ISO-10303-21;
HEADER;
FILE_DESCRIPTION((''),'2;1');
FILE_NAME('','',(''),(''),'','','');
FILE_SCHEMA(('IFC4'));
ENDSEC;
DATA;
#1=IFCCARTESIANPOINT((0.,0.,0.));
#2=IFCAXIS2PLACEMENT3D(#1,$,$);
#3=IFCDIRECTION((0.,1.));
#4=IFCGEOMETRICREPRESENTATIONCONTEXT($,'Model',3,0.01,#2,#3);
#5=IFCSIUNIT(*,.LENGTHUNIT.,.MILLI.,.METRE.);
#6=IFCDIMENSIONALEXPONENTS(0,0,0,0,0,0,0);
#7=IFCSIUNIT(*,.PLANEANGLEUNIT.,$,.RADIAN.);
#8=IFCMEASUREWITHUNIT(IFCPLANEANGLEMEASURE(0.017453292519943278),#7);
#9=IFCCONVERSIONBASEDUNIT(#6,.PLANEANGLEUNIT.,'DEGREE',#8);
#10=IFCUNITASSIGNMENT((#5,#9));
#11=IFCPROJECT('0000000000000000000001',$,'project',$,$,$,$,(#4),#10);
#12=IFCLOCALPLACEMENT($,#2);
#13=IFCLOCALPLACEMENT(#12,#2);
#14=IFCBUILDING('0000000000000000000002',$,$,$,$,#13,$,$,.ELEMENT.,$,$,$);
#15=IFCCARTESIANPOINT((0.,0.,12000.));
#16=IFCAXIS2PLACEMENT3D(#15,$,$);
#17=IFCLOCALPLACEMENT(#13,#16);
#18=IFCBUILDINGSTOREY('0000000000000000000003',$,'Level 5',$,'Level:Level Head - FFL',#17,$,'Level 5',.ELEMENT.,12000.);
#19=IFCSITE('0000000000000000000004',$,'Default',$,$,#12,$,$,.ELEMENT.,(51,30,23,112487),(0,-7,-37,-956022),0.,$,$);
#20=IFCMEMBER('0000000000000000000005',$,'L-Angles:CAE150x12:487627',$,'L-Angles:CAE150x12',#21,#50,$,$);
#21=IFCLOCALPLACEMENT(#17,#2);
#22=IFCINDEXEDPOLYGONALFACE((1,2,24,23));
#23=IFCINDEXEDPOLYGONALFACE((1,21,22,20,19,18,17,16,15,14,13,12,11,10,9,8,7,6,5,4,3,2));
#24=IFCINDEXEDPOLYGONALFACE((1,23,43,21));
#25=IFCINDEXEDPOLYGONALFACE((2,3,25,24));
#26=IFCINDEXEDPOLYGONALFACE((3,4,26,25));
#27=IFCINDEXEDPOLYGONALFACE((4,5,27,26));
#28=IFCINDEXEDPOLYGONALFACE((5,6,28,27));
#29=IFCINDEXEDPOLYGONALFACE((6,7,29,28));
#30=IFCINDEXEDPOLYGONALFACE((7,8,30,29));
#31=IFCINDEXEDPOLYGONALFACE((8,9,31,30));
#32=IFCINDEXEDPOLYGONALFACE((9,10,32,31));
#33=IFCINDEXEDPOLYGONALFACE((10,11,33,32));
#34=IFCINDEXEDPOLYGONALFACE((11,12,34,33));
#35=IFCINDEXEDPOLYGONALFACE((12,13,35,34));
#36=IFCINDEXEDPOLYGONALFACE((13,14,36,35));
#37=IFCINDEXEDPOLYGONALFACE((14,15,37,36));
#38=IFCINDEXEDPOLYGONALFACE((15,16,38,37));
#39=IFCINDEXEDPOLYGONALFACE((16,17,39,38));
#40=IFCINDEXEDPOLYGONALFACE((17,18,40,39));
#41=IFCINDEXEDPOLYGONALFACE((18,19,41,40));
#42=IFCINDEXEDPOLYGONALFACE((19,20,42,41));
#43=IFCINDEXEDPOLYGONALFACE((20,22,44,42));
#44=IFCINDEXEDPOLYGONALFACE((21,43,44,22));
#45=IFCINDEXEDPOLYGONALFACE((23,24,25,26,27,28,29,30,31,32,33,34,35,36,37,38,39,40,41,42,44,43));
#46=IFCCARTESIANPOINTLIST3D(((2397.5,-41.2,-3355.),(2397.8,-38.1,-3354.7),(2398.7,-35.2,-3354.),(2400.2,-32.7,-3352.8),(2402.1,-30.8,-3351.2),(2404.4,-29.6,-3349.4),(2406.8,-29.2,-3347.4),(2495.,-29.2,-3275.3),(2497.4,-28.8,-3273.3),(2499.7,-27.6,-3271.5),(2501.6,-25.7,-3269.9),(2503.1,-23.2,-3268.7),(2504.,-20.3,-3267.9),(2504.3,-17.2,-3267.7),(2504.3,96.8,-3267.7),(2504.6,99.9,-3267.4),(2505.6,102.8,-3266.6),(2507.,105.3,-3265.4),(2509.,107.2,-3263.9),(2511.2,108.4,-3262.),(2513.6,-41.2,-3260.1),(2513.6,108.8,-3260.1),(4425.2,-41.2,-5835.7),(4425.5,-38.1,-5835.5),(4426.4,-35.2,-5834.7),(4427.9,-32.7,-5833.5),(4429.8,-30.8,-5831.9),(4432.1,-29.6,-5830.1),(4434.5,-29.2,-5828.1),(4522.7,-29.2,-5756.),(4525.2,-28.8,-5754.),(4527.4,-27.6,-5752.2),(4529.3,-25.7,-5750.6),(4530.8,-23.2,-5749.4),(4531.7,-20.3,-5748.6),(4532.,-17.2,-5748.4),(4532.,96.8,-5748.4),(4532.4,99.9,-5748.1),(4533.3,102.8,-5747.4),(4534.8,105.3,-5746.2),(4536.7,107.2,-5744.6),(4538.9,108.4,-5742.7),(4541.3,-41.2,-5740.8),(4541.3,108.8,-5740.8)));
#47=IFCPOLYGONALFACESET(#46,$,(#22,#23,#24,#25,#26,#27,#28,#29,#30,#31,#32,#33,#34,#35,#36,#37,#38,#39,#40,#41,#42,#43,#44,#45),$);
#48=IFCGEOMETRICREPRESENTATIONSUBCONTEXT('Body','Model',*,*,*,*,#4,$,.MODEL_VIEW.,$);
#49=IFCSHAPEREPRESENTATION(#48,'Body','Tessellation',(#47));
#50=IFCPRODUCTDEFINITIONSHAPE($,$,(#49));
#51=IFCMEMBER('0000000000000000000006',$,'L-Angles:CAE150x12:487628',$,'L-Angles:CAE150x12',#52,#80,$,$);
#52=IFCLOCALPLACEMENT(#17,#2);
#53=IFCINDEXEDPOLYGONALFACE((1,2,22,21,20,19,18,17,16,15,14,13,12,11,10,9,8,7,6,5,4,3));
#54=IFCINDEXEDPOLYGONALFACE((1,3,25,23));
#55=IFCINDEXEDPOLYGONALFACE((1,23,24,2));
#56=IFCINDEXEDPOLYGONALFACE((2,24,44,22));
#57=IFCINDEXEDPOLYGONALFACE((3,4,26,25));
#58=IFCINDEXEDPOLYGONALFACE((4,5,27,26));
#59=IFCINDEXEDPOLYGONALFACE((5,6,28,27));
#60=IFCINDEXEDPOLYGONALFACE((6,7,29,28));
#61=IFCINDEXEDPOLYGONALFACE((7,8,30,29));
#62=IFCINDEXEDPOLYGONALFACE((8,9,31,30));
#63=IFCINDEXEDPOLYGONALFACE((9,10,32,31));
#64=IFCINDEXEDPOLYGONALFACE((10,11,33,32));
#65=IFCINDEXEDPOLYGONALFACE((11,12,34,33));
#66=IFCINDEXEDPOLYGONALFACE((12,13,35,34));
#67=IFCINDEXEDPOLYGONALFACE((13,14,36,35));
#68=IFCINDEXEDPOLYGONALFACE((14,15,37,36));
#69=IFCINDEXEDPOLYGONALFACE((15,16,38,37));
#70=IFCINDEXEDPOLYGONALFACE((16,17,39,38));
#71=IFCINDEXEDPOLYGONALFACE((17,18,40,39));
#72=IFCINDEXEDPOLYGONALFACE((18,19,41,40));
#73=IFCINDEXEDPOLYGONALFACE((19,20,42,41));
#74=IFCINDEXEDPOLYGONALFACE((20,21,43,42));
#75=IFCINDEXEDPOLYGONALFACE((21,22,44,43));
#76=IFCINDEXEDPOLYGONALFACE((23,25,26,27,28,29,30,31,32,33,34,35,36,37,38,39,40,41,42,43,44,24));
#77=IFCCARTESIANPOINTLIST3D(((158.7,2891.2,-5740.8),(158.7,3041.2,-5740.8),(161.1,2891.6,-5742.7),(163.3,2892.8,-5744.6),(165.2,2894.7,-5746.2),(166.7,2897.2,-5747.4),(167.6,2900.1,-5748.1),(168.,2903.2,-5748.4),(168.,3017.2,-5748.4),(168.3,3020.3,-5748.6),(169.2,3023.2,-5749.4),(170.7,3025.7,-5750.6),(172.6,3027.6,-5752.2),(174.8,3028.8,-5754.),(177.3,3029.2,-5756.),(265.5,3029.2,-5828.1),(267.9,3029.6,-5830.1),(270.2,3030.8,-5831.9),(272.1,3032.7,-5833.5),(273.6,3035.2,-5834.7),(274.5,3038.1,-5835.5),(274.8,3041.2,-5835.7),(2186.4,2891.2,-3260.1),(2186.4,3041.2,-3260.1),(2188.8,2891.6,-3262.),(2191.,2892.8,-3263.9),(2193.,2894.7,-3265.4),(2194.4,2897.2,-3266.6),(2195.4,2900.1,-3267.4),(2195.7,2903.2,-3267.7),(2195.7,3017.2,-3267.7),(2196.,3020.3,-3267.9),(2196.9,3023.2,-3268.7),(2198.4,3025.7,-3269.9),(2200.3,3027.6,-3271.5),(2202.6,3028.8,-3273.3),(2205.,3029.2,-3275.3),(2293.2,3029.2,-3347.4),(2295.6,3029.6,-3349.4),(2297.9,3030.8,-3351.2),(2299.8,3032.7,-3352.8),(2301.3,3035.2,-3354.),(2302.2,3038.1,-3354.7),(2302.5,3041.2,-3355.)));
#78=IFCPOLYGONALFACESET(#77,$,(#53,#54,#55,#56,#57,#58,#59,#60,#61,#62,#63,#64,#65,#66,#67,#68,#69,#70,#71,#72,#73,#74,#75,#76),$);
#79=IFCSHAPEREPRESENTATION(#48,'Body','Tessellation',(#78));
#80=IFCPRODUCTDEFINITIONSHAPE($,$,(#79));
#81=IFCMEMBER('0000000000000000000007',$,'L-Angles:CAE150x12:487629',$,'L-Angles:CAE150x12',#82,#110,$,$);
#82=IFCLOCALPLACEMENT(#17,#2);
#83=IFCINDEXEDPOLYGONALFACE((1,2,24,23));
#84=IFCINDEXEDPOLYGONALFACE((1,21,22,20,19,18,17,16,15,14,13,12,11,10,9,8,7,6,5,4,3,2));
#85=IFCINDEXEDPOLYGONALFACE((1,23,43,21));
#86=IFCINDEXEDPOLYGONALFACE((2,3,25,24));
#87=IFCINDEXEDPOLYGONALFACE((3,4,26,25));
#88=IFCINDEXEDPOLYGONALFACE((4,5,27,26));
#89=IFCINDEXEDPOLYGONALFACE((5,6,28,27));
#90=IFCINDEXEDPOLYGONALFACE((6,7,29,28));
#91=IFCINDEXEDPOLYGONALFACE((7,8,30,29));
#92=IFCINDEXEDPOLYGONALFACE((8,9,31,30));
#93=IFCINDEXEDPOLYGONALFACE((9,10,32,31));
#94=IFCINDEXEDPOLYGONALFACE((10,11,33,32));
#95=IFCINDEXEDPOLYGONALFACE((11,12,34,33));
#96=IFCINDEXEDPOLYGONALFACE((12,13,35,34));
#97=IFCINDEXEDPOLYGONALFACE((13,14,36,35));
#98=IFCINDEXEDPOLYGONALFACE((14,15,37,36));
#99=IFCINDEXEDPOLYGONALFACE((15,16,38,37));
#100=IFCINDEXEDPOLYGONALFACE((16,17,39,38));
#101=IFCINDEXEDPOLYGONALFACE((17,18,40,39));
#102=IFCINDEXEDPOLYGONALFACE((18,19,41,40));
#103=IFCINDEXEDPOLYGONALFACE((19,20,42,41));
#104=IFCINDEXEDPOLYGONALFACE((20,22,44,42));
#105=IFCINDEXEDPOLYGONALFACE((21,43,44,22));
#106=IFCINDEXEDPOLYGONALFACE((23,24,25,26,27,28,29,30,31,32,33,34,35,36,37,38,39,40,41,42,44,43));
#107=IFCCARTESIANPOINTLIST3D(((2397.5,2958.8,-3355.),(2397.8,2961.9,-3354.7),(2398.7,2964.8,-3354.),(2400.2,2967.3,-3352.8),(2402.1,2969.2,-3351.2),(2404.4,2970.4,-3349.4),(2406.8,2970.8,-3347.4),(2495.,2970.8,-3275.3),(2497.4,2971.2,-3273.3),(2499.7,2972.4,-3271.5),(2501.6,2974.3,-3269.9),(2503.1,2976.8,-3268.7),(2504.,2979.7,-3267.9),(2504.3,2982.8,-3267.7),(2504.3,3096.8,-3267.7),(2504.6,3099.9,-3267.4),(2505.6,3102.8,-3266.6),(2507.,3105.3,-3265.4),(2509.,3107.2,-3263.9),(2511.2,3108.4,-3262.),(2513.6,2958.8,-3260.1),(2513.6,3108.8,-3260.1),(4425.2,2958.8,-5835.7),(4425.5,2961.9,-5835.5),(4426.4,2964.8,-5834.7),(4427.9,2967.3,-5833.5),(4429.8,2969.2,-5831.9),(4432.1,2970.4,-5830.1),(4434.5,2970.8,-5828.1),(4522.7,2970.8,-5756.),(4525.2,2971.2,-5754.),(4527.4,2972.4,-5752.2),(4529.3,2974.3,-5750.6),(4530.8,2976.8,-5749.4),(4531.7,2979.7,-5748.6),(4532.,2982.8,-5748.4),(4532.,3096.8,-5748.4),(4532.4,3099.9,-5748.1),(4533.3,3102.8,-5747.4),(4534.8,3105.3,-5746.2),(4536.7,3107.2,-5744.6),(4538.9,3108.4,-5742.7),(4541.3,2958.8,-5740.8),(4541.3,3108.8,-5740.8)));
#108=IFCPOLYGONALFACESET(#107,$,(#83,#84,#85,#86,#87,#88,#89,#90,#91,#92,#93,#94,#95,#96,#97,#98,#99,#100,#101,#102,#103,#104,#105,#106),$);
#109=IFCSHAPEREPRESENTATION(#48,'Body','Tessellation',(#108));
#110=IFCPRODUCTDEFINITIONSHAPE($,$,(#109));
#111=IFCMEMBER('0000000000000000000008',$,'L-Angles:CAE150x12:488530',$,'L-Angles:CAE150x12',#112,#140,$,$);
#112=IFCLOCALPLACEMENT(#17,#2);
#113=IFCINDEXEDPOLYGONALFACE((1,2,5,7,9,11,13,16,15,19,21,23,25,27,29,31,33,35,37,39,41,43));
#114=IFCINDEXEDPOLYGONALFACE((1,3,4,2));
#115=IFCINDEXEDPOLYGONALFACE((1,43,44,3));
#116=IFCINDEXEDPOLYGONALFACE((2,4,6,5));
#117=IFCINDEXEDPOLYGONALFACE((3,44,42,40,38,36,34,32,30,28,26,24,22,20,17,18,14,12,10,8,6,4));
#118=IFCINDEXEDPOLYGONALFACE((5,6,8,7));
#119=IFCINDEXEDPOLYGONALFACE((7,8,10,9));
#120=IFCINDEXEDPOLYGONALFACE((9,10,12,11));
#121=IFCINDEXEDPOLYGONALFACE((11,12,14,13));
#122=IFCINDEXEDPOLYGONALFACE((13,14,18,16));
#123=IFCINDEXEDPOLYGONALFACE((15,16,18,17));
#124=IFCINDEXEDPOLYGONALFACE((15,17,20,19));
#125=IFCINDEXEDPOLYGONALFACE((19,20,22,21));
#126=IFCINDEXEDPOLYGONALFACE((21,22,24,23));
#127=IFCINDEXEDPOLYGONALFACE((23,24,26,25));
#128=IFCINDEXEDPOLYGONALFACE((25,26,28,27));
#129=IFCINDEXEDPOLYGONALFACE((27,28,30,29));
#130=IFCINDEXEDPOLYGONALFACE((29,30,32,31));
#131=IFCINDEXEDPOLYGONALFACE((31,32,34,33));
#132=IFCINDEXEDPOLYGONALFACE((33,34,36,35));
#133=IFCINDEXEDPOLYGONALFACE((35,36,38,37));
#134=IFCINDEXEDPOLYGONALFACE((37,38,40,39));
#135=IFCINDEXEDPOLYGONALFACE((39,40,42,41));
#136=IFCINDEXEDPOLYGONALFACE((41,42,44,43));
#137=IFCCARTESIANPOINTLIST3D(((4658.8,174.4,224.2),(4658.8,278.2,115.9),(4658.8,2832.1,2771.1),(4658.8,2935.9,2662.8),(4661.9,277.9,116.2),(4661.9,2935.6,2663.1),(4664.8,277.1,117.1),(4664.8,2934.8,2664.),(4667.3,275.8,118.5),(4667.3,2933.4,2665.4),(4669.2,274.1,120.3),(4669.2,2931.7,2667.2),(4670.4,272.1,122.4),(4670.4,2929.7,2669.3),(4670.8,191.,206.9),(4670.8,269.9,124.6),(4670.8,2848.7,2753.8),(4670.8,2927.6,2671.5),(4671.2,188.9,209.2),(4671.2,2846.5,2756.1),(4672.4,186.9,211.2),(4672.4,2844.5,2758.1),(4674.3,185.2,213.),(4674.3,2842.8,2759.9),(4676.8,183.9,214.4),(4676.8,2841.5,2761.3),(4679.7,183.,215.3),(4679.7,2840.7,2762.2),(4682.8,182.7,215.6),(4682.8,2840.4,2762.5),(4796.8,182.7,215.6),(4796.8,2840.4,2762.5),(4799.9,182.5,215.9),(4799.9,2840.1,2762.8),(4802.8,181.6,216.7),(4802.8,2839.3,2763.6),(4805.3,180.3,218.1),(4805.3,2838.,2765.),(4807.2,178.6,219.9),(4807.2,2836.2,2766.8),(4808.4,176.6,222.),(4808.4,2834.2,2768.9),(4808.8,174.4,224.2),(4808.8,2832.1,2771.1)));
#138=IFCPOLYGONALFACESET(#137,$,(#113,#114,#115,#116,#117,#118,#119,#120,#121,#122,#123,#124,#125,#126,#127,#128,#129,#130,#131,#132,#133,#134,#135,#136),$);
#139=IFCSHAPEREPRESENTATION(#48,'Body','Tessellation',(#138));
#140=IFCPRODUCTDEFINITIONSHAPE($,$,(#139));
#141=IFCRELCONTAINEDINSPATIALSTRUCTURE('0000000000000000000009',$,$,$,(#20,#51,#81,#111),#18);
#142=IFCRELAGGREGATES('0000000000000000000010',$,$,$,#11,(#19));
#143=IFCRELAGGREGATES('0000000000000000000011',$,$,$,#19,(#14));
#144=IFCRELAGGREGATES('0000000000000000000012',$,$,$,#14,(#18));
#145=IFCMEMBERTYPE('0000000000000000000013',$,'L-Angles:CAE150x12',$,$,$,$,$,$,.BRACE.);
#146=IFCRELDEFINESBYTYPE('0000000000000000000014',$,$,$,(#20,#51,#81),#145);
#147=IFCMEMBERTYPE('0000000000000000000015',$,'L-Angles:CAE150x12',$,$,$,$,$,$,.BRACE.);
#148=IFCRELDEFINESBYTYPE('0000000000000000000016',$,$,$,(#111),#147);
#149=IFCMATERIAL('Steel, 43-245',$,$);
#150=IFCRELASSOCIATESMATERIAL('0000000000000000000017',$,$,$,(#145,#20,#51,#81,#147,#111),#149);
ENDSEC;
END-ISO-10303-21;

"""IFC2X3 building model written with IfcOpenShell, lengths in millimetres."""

from ifc_helpers import new_model, entity, si_unit, converted_unit, direction, frame, frame_2d, origin, place, context, subcontext, project, spatial, polyline, circle_curve, parameter, trimmed, segment, composite_curve, outline, extrude, source, transform, mapped, material, type_object, type_shapes, element, save


model = new_model("IFC2X3")

# Units and contexts
model_context = context("Model", 3, precision=0.01, world=origin(), true_north=direction((0.0, 1.0)))
body_context = subcontext(model_context, "Body", "Model", "MODEL_VIEW")
ifc_project = project(units=[si_unit("LENGTHUNIT", "METRE", prefix="MILLI"), converted_unit("PLANEANGLEUNIT", "DEGREE", entity("IfcPlaneAngleMeasure", 0.017453292519943278), si_unit("PLANEANGLEUNIT", "RADIAN"), dimensions=[0, 0, 0, 0, 0, 0, 0])], contexts=[model_context])

# Site, building, storey
site_placement = place(None, origin())
site = spatial("IfcSite", under=ifc_project, at=site_placement, Name="Default", CompositionType="ELEMENT", RefLatitude=(51, 30, 23, 112487), RefLongitude=(0, -7, -37, -956022), RefElevation=0.0)
building_placement = place(site_placement, origin())
building = spatial("IfcBuilding", under=site, at=building_placement, CompositionType="ELEMENT")
storey_placement = place(building_placement, frame((0.0, 0.0, 12000.0)))
storey = spatial("IfcBuildingStorey", under=building, at=storey_placement, Name="Level 5", ObjectType="Level:Level Head - FFL", LongName="Level 5", CompositionType="ELEMENT", Elevation=12000.0)

# Shared definitions
ifc_material = material(Name="Steel, 43-245")

# Members
member_type_1 = type_object("IfcMemberType", Name="L-Angles:CAE150x12", PredefinedType="BRACE", material=ifc_material)
shared_shape_1 = source(origin(), body_context, "Body", "SweptSolid", [
    extrude(outline(composite_curve([segment(polyline([(-102.0, -48.0), (48.0, -48.0)]), True, "CONTINUOUS"), segment(polyline([(48.0, -48.0), (48.0, 102.0)]), True, "CONTINUOUS"), segment(trimmed(circle_curve(frame_2d((48.0, 90.0), x_axis=(0.0, 1.0)), 12.0), [parameter(0.0)], [parameter(90.0)], True, "PARAMETER"), True, "CONTINUOUS"), segment(polyline([(36.0, 90.0), (36.0, -24.0)]), True, "CONTINUOUS"), segment(trimmed(circle_curve(frame_2d((24.0, -24.0), x_axis=(1.0, 0.0)), 12.0), [parameter(270.0)], [parameter(0.0)], True, "PARAMETER"), False, "CONTINUOUS"), segment(polyline([(24.0, -36.0), (-90.0, -36.0)]), True, "CONTINUOUS"), segment(trimmed(circle_curve(frame_2d((-90.0, -48.0), x_axis=(0.0, 1.0)), 12.0), [parameter(0.0)], [parameter(90.0)], True, "PARAMETER"), True, "CONTINUOUS")], self_intersect=False)), frame((-1555.5, -6.8, -6.8), z_axis=(1.0, 0.0, 0.0), x_axis=(0.0, 0.0, 1.0)), (0.0, 0.0, 1.0), 3204.0),
])
type_shapes(member_type_1, [shared_shape_1])
for number, where, z_axis, x_axis, name in (
    (1, (3525.0, 0.0, -4562.5), (0.774257, 0.0, 0.632871), (-0.632871, 0.0, 0.774257), "L-Angles:CAE150x12:487627"),
    (2, (1175.0, 3000.0, -4562.5), (-0.774257, 0.0, 0.632871), (0.632871, 0.0, 0.774257), "L-Angles:CAE150x12:487628"),
    (3, (3525.0, 3000.0, -4562.5), (0.774257, 0.0, 0.632871), (-0.632871, 0.0, 0.774257), "L-Angles:CAE150x12:487629"),
):
    element("IfcMember", number, at=place(storey_placement, frame(where, z_axis=z_axis, x_axis=x_axis)), inside=storey, type_object=member_type_1, material=ifc_material, Name=name, ObjectType="L-Angles:CAE150x12", context=body_context, shape_type="MappedRepresentation", body=[
        mapped(shared_shape_1, transform((0.0, 0.0, 0.0), scale=1.0)),
    ])
member_type_2 = type_object("IfcMemberType", Name="L-Angles:CAE150x12", PredefinedType="BRACE", material=ifc_material)
shared_shape_2 = source(origin(), body_context, "Body", "SweptSolid", [
    extrude(outline(composite_curve([segment(polyline([(-102.0, -48.0), (48.0, -48.0)]), True, "CONTINUOUS"), segment(polyline([(48.0, -48.0), (48.0, 102.0)]), True, "CONTINUOUS"), segment(trimmed(circle_curve(frame_2d((48.0, 90.0), x_axis=(0.0, 1.0)), 12.0), [parameter(0.0)], [parameter(90.0)], True, "PARAMETER"), True, "CONTINUOUS"), segment(polyline([(36.0, 90.0), (36.0, -24.0)]), True, "CONTINUOUS"), segment(trimmed(circle_curve(frame_2d((24.0, -24.0), x_axis=(1.0, 0.0)), 12.0), [parameter(270.0)], [parameter(0.0)], True, "PARAMETER"), False, "CONTINUOUS"), segment(polyline([(24.0, -36.0), (-90.0, -36.0)]), True, "CONTINUOUS"), segment(trimmed(circle_curve(frame_2d((-90.0, -48.0), x_axis=(0.0, 1.0)), 12.0), [parameter(0.0)], [parameter(90.0)], True, "PARAMETER"), True, "CONTINUOUS")], self_intersect=False)), frame((-1796.5, -6.8, -6.8), z_axis=(1.0, 0.0, 0.0), x_axis=(0.0, 0.0, 1.0)), (0.0, 0.0, 1.0), 3681.0),
])
type_shapes(member_type_2, [shared_shape_2])
member_placement = place(storey_placement, frame((4700.0, 1500.0, 1437.5), z_axis=(0.0, -0.691905, 0.721988), x_axis=(0.0, 0.721988, 0.691905)))
element("IfcMember", 4, at=member_placement, inside=storey, type_object=member_type_2, material=ifc_material, Name="L-Angles:CAE150x12:488530", ObjectType="L-Angles:CAE150x12", context=body_context, shape_type="MappedRepresentation", body=[
    mapped(shared_shape_2, transform((0.0, 0.0, 0.0), scale=1.0)),
])

save(model, "model.ifc")
